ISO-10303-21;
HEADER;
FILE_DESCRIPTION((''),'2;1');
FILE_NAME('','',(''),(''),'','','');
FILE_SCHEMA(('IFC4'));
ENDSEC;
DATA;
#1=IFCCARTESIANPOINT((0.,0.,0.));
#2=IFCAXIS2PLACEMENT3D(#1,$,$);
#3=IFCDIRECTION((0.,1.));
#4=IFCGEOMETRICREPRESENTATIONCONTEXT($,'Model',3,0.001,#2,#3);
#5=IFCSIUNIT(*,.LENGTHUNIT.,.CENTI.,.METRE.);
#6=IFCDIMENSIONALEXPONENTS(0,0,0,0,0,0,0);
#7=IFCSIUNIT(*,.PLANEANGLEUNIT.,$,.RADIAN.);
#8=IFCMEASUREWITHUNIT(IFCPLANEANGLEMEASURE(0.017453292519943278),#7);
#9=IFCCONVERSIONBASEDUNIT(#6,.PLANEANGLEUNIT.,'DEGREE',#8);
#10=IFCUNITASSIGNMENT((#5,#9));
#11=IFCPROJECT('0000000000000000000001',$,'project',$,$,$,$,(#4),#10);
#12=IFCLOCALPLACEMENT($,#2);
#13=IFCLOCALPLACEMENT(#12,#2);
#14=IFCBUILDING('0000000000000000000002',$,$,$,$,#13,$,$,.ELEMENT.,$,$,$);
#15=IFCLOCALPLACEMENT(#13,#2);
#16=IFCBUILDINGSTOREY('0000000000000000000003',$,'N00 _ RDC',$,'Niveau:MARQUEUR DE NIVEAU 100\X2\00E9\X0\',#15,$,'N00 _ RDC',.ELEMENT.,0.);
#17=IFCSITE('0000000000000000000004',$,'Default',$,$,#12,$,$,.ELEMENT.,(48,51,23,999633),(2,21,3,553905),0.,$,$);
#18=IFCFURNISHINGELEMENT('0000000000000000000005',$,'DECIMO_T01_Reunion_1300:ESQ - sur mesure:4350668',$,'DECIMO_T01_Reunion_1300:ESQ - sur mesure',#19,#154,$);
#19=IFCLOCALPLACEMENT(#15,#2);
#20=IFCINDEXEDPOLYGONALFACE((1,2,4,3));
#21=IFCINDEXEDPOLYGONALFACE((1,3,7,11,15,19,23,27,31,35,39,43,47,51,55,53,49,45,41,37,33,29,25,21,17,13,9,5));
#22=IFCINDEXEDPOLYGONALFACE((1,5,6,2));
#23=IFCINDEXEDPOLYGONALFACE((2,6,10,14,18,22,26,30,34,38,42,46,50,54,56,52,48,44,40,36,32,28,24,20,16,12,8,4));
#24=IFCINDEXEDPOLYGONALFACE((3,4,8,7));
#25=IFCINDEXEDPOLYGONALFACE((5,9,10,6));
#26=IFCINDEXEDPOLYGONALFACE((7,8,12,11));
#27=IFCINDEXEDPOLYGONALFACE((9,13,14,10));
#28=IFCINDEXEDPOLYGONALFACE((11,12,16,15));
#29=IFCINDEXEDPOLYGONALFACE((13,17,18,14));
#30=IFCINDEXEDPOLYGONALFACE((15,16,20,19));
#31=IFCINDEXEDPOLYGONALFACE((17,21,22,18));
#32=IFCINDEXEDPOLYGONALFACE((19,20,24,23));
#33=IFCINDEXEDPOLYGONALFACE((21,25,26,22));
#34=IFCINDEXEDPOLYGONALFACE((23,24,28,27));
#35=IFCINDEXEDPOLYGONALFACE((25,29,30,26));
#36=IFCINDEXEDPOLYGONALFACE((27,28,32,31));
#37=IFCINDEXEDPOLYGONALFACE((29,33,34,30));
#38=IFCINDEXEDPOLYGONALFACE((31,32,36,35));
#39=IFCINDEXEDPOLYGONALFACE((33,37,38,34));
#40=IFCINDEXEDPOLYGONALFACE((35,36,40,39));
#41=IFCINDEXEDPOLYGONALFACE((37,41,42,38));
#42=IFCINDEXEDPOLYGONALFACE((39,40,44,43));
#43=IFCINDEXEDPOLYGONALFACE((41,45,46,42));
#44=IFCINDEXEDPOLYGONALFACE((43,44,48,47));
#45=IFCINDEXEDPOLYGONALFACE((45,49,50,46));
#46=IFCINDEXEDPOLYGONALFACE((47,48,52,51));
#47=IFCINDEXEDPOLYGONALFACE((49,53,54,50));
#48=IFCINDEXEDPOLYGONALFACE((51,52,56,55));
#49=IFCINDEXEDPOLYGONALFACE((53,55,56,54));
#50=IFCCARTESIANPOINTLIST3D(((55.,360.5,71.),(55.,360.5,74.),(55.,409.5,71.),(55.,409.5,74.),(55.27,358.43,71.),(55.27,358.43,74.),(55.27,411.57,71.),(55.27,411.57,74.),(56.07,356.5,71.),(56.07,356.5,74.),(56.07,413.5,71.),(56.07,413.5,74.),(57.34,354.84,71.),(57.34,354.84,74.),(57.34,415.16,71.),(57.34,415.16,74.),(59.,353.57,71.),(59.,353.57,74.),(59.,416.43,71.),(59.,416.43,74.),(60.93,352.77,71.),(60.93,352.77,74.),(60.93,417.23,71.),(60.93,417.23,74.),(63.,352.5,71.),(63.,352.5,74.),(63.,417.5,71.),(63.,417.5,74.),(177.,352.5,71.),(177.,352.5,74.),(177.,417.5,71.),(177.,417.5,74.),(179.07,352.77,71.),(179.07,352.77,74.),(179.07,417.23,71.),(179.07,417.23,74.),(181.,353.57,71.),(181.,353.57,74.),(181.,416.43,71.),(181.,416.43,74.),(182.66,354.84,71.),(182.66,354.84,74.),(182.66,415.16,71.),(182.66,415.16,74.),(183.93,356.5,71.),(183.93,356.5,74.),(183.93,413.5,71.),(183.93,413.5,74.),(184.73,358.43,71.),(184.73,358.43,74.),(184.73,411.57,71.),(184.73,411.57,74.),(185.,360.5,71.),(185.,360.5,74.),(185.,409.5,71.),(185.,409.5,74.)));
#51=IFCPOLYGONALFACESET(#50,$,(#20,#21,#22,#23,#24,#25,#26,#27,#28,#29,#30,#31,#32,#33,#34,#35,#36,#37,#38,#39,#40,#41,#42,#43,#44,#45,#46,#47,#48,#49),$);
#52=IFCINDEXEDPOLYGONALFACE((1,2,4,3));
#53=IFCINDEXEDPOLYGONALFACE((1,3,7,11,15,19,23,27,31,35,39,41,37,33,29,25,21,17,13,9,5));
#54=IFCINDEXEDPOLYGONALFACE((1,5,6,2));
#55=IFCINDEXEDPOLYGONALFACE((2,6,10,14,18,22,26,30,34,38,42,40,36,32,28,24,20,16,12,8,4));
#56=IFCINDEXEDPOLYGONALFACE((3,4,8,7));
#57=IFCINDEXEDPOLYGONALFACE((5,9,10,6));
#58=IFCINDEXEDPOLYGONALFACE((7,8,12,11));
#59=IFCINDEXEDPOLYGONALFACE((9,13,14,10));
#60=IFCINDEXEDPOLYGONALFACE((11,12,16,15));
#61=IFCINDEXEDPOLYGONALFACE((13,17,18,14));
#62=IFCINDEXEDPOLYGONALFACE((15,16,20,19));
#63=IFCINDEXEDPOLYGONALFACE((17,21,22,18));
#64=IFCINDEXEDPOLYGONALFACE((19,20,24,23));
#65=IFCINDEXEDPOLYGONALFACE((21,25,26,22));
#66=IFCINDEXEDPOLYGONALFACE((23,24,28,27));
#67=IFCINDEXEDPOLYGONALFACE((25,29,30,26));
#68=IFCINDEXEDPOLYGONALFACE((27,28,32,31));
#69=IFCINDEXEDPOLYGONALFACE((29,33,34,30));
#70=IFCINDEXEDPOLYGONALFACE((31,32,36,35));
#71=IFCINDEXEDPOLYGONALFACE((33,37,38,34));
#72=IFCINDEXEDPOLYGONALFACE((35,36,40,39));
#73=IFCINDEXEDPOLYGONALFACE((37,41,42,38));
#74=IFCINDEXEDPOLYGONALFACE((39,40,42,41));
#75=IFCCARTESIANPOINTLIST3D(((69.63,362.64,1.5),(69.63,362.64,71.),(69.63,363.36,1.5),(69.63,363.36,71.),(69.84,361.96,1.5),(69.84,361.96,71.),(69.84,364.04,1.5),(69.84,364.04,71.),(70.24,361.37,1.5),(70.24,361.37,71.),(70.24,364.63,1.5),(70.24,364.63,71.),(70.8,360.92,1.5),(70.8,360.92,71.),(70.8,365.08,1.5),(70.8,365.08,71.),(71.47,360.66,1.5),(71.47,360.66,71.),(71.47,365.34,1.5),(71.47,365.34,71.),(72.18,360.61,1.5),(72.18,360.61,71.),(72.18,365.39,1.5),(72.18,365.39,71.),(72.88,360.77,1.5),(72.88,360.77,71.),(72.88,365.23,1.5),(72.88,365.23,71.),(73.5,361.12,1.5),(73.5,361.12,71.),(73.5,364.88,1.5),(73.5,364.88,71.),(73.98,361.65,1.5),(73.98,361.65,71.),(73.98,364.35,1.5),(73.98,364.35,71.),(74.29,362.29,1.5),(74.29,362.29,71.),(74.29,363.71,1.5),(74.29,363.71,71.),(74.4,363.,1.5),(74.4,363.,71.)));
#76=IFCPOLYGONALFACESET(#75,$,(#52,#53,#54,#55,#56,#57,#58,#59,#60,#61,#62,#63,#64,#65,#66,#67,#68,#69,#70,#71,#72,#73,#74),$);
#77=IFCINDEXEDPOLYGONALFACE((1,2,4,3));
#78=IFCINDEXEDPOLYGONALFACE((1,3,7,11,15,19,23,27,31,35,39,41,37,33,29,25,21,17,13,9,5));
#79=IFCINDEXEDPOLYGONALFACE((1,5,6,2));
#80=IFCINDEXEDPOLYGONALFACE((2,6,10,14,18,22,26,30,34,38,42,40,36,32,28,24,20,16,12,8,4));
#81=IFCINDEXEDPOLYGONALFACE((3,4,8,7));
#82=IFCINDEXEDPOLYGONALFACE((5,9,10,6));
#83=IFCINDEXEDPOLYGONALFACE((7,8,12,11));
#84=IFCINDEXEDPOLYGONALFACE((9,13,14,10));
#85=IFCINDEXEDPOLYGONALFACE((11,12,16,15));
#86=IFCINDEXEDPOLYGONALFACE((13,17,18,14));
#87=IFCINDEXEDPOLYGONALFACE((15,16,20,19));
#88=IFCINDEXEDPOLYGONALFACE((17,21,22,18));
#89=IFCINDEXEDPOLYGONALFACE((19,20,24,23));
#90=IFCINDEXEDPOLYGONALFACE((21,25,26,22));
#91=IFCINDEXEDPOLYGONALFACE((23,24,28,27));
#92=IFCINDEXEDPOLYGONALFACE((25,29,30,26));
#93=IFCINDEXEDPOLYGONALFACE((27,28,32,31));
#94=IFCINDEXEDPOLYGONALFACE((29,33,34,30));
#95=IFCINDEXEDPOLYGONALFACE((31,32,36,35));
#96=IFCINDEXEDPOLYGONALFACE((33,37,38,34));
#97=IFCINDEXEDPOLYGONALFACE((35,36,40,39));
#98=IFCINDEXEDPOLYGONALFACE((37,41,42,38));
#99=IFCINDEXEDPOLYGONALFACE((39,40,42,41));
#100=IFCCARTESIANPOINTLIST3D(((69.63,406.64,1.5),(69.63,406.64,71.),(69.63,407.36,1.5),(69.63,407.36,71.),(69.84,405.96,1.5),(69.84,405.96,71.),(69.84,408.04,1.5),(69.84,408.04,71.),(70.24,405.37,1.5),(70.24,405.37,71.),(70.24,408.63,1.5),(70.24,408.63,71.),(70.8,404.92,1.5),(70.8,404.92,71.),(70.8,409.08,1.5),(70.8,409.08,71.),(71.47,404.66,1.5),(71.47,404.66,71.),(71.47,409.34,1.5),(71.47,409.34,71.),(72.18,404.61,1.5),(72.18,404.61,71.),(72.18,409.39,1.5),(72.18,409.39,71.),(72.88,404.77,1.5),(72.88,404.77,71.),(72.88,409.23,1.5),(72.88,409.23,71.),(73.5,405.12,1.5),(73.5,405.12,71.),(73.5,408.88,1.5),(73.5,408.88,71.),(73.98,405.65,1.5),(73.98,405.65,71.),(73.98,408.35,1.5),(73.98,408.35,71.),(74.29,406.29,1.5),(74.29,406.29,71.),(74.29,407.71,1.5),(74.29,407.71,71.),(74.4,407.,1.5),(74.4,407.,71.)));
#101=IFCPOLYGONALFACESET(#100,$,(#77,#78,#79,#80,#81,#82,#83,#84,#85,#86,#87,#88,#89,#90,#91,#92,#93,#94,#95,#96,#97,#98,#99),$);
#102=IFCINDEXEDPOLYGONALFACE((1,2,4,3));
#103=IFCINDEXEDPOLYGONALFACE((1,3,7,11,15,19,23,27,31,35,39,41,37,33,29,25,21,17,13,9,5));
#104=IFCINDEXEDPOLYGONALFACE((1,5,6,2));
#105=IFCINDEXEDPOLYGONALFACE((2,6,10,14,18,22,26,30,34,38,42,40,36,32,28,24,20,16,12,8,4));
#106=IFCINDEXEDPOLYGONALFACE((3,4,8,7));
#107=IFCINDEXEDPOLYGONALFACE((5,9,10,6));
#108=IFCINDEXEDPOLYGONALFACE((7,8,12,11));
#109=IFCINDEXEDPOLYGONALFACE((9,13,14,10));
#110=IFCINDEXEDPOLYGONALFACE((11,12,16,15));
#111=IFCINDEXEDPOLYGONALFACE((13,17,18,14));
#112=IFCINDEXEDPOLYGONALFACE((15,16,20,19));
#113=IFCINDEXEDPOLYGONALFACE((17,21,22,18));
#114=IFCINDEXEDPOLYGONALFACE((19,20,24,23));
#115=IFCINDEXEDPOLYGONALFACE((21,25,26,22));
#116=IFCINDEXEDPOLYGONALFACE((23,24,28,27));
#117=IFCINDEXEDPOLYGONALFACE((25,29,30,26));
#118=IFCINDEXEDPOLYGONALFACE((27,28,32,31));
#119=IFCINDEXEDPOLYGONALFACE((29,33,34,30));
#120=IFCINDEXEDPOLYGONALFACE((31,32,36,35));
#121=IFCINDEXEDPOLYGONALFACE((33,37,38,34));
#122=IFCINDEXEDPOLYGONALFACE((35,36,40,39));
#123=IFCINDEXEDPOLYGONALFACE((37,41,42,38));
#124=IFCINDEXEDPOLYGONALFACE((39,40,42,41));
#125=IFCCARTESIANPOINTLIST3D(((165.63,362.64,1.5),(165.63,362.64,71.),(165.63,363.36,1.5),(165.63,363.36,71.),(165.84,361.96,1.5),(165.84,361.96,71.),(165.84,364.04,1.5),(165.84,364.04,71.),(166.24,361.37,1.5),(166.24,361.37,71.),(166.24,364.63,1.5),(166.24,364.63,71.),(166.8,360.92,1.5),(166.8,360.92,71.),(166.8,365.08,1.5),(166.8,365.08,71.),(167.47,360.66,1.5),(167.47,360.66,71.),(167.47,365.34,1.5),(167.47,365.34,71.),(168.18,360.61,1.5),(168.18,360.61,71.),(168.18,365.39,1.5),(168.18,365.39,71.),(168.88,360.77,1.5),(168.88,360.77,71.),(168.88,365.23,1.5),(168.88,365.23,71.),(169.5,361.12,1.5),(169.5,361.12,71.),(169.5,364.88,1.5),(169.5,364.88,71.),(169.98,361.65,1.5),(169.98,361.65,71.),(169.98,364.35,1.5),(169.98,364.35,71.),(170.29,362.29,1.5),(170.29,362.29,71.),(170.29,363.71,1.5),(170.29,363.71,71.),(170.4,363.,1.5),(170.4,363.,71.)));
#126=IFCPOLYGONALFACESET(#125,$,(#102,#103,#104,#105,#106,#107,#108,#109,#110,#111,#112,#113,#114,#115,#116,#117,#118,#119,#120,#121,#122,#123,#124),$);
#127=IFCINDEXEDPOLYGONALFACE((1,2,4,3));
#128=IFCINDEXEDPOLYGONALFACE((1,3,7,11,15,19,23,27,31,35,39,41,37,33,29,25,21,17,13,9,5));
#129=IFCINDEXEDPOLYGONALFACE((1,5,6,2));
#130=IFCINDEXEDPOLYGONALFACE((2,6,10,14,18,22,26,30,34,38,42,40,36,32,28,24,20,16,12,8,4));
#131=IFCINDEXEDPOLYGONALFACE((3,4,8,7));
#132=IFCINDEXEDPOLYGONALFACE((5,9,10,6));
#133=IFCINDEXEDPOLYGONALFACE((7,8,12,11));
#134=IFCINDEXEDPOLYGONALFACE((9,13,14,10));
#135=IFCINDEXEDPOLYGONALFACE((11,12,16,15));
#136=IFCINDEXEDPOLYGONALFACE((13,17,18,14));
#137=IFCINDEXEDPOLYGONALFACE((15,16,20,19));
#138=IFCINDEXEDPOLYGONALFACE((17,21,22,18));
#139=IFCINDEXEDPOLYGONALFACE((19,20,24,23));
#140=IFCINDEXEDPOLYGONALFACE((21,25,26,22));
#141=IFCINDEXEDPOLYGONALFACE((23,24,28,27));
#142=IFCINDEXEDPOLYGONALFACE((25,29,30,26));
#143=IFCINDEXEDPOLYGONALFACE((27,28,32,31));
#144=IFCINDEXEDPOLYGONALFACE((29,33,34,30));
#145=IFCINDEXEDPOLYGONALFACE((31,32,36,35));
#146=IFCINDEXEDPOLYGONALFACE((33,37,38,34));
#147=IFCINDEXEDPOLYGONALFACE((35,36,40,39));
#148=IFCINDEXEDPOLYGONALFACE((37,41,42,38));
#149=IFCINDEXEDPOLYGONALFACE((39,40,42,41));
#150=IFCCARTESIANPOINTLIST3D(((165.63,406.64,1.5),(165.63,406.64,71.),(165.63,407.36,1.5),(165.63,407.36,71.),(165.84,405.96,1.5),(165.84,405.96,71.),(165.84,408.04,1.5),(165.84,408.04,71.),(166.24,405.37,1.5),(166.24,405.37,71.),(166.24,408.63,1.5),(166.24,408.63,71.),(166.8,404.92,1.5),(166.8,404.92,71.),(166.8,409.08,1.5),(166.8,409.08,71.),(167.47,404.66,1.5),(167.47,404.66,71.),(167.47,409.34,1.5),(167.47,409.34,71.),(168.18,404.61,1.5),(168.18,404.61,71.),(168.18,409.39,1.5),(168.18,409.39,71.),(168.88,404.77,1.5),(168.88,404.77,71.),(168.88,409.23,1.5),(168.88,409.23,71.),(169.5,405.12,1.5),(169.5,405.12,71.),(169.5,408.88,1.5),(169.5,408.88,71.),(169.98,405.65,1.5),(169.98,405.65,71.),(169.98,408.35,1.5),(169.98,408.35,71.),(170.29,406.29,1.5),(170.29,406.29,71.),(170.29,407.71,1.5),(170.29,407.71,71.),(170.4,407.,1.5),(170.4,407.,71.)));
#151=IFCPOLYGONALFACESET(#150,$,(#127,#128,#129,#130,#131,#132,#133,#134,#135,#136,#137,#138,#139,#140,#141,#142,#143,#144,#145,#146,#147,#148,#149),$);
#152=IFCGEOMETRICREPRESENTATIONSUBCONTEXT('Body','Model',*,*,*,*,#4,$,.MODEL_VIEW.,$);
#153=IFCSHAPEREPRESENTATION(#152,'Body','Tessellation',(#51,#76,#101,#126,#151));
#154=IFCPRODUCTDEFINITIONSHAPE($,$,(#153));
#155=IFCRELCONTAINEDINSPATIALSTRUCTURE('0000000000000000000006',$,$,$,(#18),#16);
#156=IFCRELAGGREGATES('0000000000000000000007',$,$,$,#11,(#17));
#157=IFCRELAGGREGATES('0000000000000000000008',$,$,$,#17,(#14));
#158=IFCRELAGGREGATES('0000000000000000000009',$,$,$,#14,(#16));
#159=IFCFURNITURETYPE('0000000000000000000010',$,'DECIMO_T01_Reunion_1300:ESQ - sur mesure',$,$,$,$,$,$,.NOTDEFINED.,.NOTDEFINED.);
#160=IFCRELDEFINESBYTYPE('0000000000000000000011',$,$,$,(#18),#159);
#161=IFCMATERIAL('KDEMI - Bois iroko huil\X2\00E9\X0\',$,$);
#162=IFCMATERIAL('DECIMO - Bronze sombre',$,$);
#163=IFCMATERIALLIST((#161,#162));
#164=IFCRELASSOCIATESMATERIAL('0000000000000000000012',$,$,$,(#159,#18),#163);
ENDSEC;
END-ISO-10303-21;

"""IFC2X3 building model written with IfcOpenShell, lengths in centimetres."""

from ifc_helpers import new_model, entity, si_unit, converted_unit, direction, frame, frame_2d, origin, origin_2d_with_axis, place, context, subcontext, project, spatial, polyline, circle_curve, parameter, trimmed, segment, composite_curve, circle, outline, extrude, source, transform, mapped, material, material_list, type_object, type_shapes, element, save


model = new_model("IFC2X3")

# Units and contexts
model_context = context("Model", 3, precision=0.001, world=origin(), true_north=direction((0.0, 1.0)))
body_context = subcontext(model_context, "Body", "Model", "MODEL_VIEW")
ifc_project = project(units=[si_unit("LENGTHUNIT", "METRE", prefix="CENTI"), converted_unit("PLANEANGLEUNIT", "DEGREE", entity("IfcPlaneAngleMeasure", 0.017453292519943278), si_unit("PLANEANGLEUNIT", "RADIAN"), dimensions=[0, 0, 0, 0, 0, 0, 0])], contexts=[model_context])

# Site, building, storey
site_placement = place(None, origin())
site = spatial("IfcSite", under=ifc_project, at=site_placement, Name="Default", CompositionType="ELEMENT", RefLatitude=(48, 51, 23, 999633), RefLongitude=(2, 21, 3, 553905), RefElevation=0.0)
building_placement = place(site_placement, origin())
building = spatial("IfcBuilding", under=site, at=building_placement, CompositionType="ELEMENT")
storey_placement = place(building_placement, origin())
storey = spatial("IfcBuildingStorey", under=building, at=storey_placement, Name="N00 _ RDC", ObjectType="Niveau:MARQUEUR DE NIVEAU 100é", LongName="N00 _ RDC", CompositionType="ELEMENT", Elevation=0.0)

# Furnishing element
ifc_material_1 = material(Name="DECIMO - Bronze sombre")
ifc_material_2 = material(Name="KDEMI - Bois iroko huilé")
ifc_material_list_1 = material_list([ifc_material_2, ifc_material_1])
furniture_type_1 = type_object("IfcFurnitureType", Name="DECIMO_T01_Reunion_1300:ESQ - sur mesure", AssemblyPlace="NOTDEFINED", material=ifc_material_list_1)
shared_shape_1 = source(origin(), body_context, "Body", "SweptSolid", [
    extrude(outline(composite_curve([segment(polyline([(-57.0, -32.5), (57.0, -32.5)]), True, "CONTINUOUS"), segment(trimmed(circle_curve(frame_2d((57.0, -24.5), x_axis=(1.0, 0.0)), 8.0), [parameter(270.0)], [parameter(0.0)], True, "PARAMETER"), True, "CONTINUOUS"), segment(polyline([(65.0, -24.5), (65.0, 24.5)]), True, "CONTINUOUS"), segment(trimmed(circle_curve(frame_2d((57.0, 24.5), x_axis=(1.0, 0.0)), 8.0), [parameter(0.0)], [parameter(90.0)], True, "PARAMETER"), True, "CONTINUOUS"), segment(polyline([(57.0, 32.5), (-57.0, 32.5)]), True, "CONTINUOUS"), segment(trimmed(circle_curve(frame_2d((-57.0, 24.5), x_axis=(1.0, 0.0)), 8.0), [parameter(90.0)], [parameter(180.0)], True, "PARAMETER"), True, "CONTINUOUS"), segment(polyline([(-65.0, 24.5), (-65.0, -24.5)]), True, "CONTINUOUS"), segment(trimmed(circle_curve(frame_2d((-57.0, -24.5), x_axis=(1.0, 0.0)), 8.0), [parameter(180.0)], [parameter(270.0)], True, "PARAMETER"), True, "CONTINUOUS")], self_intersect=False)), frame((0.0, 0.0, 71.0)), (0.0, 0.0, 1.0), 3.0),
    extrude(circle(Radius=2.4, at=origin_2d_with_axis()), frame((-48.0, -22.0, 1.5)), (0.0, 0.0, 1.0), 69.5),
    extrude(circle(Radius=2.4, at=origin_2d_with_axis()), frame((-48.0, 22.0, 1.5)), (0.0, 0.0, 1.0), 69.5),
    extrude(circle(Radius=2.4, at=origin_2d_with_axis()), frame((48.0, -22.0, 1.5)), (0.0, 0.0, 1.0), 69.5),
    extrude(circle(Radius=2.4, at=origin_2d_with_axis()), frame((48.0, 22.0, 1.5)), (0.0, 0.0, 1.0), 69.5),
])
type_shapes(furniture_type_1, [shared_shape_1])
furnishing_1_placement = place(storey_placement, frame((120.0, 385.0, 0.0)))
element("IfcFurnishingElement", 1, at=furnishing_1_placement, inside=storey, type_object=furniture_type_1, material=ifc_material_list_1, Name="DECIMO_T01_Reunion_1300:ESQ - sur mesure:4350668", ObjectType="DECIMO_T01_Reunion_1300:ESQ - sur mesure", context=body_context, shape_type="MappedRepresentation", body=[
    mapped(shared_shape_1, transform((0.0, 0.0, 0.0), scale=1.0)),
])

save(model, "model.ifc")
